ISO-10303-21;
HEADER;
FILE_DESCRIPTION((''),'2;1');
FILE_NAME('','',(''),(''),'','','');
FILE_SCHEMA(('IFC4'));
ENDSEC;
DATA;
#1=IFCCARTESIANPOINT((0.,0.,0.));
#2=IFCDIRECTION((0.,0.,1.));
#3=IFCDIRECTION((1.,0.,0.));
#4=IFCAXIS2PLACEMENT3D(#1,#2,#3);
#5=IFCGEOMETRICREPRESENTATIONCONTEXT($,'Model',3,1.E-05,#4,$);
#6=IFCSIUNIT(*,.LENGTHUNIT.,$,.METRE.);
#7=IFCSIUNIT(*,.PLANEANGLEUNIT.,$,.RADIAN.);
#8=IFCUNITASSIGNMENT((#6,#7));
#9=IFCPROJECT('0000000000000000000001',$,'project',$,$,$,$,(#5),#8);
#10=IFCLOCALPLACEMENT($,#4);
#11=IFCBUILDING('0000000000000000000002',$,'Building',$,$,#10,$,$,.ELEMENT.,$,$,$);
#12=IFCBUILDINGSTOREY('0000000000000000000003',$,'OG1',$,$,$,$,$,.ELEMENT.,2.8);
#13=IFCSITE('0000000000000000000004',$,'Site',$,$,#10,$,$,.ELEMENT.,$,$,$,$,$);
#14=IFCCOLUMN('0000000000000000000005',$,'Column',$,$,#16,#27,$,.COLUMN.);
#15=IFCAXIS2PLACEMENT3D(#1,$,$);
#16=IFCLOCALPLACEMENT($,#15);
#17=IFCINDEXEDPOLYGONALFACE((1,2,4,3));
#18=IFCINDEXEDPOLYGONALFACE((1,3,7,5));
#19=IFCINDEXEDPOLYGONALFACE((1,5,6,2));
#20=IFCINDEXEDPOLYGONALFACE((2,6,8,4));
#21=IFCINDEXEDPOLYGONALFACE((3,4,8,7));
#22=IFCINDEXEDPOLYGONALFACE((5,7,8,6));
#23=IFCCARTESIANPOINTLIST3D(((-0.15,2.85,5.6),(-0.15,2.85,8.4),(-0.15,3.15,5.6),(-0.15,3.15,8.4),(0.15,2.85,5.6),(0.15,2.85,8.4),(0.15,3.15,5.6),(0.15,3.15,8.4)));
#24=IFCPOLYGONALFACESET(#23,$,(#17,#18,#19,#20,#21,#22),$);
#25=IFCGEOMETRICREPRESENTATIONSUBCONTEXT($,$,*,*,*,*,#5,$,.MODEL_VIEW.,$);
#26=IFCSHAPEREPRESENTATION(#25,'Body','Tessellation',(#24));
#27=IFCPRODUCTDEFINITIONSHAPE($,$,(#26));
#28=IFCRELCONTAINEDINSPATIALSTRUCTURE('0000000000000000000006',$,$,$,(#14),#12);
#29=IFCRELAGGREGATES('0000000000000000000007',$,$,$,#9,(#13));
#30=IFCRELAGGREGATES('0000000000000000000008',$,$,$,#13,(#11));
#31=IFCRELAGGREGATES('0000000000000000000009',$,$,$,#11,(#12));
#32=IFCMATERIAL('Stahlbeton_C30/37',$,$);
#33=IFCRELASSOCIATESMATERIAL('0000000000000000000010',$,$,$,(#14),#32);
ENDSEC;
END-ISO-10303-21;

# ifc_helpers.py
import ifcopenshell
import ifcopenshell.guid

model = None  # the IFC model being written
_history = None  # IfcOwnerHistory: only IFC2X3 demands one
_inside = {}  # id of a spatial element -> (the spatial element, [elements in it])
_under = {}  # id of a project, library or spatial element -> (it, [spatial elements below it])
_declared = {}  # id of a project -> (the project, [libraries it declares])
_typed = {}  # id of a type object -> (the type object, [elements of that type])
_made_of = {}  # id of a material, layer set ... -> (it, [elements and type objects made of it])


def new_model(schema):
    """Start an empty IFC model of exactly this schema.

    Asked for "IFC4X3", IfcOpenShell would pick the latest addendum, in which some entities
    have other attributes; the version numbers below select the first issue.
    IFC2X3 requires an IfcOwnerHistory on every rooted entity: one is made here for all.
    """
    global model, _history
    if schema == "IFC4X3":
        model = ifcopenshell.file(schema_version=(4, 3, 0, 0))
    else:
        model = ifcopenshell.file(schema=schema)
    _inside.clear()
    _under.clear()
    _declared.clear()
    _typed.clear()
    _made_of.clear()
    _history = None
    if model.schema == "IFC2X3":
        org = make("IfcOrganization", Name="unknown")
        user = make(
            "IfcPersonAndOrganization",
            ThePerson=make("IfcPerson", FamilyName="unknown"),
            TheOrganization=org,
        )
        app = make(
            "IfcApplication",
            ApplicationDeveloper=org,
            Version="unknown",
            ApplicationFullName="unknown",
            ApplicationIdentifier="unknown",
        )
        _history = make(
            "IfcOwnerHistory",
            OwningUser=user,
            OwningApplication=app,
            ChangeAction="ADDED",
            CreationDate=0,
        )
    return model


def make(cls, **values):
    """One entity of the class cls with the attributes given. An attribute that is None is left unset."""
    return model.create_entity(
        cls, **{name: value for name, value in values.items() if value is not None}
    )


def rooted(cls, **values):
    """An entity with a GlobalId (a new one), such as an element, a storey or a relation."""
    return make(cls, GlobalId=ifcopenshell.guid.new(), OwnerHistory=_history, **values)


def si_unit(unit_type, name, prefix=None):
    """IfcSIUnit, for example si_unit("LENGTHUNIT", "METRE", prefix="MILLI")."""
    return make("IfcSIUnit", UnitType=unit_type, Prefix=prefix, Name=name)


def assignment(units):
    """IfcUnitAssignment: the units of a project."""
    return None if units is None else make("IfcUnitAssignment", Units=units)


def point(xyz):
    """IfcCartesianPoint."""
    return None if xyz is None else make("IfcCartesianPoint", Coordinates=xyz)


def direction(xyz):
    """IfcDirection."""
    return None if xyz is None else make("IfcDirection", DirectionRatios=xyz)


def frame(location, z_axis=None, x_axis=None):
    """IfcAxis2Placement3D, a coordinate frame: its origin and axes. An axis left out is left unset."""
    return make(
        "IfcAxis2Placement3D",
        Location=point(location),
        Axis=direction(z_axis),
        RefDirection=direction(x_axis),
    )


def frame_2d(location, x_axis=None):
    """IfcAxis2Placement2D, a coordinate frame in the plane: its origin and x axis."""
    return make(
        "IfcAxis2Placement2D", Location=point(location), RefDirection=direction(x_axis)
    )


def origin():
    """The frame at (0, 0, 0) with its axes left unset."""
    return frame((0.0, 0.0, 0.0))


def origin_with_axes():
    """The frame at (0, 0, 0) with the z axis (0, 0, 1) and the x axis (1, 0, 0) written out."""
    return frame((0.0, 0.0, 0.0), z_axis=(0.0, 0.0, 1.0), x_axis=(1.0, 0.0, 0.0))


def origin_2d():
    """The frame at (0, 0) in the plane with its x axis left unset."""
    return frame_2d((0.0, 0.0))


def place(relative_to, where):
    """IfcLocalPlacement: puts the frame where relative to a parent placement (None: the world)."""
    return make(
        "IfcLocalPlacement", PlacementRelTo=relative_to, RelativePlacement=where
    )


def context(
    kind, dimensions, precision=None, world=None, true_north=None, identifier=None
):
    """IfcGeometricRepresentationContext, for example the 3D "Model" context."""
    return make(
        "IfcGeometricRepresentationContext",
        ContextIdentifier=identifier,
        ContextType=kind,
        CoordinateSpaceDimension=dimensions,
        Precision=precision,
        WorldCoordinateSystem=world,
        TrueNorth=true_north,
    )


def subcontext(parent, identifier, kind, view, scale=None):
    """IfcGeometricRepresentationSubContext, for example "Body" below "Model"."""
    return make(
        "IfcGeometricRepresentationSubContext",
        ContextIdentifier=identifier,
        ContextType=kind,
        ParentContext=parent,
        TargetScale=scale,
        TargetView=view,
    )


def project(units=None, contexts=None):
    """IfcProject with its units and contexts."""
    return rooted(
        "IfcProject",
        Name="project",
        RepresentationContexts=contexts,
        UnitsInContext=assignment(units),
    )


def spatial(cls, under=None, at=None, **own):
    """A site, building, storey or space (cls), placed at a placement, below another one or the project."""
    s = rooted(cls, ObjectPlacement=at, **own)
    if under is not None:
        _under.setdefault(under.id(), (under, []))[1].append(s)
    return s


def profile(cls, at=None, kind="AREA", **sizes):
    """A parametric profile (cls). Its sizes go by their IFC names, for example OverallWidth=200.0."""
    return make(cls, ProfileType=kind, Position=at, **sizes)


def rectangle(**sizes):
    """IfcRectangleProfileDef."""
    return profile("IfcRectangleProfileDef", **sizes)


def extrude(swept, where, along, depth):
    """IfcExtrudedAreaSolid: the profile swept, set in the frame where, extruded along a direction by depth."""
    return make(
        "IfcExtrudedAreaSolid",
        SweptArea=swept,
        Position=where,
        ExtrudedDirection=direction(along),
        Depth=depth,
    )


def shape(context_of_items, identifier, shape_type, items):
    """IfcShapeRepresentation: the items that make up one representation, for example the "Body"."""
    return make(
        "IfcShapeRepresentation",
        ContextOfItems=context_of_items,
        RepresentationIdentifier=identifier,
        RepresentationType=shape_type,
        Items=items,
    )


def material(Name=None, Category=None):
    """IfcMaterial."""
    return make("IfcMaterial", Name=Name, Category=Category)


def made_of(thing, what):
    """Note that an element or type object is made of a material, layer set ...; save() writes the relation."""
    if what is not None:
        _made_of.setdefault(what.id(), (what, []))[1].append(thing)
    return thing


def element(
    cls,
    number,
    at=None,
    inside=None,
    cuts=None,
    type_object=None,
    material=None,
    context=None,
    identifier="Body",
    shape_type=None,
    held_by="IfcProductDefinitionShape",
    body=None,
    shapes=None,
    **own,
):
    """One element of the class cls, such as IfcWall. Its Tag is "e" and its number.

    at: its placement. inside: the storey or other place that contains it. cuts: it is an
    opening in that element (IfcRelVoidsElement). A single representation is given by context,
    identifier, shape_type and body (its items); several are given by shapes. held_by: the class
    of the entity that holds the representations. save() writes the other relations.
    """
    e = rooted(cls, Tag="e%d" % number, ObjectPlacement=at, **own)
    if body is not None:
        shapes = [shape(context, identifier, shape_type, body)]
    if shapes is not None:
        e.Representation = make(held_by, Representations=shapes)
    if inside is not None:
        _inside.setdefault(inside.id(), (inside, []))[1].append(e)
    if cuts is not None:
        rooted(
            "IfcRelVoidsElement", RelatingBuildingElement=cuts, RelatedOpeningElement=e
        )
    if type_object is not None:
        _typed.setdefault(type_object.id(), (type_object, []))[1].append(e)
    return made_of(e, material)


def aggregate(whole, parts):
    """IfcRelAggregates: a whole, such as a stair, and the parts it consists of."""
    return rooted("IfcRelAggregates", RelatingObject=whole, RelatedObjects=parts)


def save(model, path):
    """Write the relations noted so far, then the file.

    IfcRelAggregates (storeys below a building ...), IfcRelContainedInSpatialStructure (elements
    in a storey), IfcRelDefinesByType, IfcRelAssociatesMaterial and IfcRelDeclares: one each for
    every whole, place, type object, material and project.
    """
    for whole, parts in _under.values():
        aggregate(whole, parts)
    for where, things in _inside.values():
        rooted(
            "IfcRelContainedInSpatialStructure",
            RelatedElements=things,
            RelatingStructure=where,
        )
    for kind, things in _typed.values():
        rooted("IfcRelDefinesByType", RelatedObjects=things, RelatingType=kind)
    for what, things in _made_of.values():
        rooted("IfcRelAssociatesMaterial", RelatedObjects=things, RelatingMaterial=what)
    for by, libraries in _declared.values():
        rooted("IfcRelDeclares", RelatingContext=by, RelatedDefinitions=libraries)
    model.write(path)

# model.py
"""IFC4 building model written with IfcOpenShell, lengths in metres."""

from ifc_helpers import new_model, si_unit, frame, origin, origin_with_axes, origin_2d, place, context, subcontext, project, spatial, rectangle, extrude, material, element, save


model = new_model("IFC4")

# Units and contexts
model_context = context("Model", 3, precision=1e-05, world=origin_with_axes())
sub_context = subcontext(model_context, None, None, "MODEL_VIEW")
ifc_project = project(units=[si_unit("LENGTHUNIT", "METRE"), si_unit("PLANEANGLEUNIT", "RADIAN")], contexts=[model_context])

# Site, building, storey
placement_1 = place(None, origin_with_axes())
site = spatial("IfcSite", under=ifc_project, at=placement_1, Name="Site", CompositionType="ELEMENT")
building = spatial("IfcBuilding", under=site, at=placement_1, Name="Building", CompositionType="ELEMENT")
storey = spatial("IfcBuildingStorey", under=building, Name="OG1", CompositionType="ELEMENT", Elevation=2.8)

# Column
ifc_material = material(Name="Stahlbeton_C30/37")
placement_2 = place(None, origin_with_axes())
placement_3 = place(placement_2, frame((0.0, 0.0, 2.8)))
column_placement = place(placement_3, frame((0.0, 3.0, 2.8)))
element("IfcColumn", 1, at=column_placement, inside=storey, material=ifc_material, Name="Column", PredefinedType="COLUMN", context=sub_context, shape_type="SweptSolid", body=[
    extrude(rectangle(XDim=0.3, YDim=0.3, at=origin_2d()), origin(), (0.0, 0.0, 1.0), 2.8),
])

save(model, "model.ifc")
